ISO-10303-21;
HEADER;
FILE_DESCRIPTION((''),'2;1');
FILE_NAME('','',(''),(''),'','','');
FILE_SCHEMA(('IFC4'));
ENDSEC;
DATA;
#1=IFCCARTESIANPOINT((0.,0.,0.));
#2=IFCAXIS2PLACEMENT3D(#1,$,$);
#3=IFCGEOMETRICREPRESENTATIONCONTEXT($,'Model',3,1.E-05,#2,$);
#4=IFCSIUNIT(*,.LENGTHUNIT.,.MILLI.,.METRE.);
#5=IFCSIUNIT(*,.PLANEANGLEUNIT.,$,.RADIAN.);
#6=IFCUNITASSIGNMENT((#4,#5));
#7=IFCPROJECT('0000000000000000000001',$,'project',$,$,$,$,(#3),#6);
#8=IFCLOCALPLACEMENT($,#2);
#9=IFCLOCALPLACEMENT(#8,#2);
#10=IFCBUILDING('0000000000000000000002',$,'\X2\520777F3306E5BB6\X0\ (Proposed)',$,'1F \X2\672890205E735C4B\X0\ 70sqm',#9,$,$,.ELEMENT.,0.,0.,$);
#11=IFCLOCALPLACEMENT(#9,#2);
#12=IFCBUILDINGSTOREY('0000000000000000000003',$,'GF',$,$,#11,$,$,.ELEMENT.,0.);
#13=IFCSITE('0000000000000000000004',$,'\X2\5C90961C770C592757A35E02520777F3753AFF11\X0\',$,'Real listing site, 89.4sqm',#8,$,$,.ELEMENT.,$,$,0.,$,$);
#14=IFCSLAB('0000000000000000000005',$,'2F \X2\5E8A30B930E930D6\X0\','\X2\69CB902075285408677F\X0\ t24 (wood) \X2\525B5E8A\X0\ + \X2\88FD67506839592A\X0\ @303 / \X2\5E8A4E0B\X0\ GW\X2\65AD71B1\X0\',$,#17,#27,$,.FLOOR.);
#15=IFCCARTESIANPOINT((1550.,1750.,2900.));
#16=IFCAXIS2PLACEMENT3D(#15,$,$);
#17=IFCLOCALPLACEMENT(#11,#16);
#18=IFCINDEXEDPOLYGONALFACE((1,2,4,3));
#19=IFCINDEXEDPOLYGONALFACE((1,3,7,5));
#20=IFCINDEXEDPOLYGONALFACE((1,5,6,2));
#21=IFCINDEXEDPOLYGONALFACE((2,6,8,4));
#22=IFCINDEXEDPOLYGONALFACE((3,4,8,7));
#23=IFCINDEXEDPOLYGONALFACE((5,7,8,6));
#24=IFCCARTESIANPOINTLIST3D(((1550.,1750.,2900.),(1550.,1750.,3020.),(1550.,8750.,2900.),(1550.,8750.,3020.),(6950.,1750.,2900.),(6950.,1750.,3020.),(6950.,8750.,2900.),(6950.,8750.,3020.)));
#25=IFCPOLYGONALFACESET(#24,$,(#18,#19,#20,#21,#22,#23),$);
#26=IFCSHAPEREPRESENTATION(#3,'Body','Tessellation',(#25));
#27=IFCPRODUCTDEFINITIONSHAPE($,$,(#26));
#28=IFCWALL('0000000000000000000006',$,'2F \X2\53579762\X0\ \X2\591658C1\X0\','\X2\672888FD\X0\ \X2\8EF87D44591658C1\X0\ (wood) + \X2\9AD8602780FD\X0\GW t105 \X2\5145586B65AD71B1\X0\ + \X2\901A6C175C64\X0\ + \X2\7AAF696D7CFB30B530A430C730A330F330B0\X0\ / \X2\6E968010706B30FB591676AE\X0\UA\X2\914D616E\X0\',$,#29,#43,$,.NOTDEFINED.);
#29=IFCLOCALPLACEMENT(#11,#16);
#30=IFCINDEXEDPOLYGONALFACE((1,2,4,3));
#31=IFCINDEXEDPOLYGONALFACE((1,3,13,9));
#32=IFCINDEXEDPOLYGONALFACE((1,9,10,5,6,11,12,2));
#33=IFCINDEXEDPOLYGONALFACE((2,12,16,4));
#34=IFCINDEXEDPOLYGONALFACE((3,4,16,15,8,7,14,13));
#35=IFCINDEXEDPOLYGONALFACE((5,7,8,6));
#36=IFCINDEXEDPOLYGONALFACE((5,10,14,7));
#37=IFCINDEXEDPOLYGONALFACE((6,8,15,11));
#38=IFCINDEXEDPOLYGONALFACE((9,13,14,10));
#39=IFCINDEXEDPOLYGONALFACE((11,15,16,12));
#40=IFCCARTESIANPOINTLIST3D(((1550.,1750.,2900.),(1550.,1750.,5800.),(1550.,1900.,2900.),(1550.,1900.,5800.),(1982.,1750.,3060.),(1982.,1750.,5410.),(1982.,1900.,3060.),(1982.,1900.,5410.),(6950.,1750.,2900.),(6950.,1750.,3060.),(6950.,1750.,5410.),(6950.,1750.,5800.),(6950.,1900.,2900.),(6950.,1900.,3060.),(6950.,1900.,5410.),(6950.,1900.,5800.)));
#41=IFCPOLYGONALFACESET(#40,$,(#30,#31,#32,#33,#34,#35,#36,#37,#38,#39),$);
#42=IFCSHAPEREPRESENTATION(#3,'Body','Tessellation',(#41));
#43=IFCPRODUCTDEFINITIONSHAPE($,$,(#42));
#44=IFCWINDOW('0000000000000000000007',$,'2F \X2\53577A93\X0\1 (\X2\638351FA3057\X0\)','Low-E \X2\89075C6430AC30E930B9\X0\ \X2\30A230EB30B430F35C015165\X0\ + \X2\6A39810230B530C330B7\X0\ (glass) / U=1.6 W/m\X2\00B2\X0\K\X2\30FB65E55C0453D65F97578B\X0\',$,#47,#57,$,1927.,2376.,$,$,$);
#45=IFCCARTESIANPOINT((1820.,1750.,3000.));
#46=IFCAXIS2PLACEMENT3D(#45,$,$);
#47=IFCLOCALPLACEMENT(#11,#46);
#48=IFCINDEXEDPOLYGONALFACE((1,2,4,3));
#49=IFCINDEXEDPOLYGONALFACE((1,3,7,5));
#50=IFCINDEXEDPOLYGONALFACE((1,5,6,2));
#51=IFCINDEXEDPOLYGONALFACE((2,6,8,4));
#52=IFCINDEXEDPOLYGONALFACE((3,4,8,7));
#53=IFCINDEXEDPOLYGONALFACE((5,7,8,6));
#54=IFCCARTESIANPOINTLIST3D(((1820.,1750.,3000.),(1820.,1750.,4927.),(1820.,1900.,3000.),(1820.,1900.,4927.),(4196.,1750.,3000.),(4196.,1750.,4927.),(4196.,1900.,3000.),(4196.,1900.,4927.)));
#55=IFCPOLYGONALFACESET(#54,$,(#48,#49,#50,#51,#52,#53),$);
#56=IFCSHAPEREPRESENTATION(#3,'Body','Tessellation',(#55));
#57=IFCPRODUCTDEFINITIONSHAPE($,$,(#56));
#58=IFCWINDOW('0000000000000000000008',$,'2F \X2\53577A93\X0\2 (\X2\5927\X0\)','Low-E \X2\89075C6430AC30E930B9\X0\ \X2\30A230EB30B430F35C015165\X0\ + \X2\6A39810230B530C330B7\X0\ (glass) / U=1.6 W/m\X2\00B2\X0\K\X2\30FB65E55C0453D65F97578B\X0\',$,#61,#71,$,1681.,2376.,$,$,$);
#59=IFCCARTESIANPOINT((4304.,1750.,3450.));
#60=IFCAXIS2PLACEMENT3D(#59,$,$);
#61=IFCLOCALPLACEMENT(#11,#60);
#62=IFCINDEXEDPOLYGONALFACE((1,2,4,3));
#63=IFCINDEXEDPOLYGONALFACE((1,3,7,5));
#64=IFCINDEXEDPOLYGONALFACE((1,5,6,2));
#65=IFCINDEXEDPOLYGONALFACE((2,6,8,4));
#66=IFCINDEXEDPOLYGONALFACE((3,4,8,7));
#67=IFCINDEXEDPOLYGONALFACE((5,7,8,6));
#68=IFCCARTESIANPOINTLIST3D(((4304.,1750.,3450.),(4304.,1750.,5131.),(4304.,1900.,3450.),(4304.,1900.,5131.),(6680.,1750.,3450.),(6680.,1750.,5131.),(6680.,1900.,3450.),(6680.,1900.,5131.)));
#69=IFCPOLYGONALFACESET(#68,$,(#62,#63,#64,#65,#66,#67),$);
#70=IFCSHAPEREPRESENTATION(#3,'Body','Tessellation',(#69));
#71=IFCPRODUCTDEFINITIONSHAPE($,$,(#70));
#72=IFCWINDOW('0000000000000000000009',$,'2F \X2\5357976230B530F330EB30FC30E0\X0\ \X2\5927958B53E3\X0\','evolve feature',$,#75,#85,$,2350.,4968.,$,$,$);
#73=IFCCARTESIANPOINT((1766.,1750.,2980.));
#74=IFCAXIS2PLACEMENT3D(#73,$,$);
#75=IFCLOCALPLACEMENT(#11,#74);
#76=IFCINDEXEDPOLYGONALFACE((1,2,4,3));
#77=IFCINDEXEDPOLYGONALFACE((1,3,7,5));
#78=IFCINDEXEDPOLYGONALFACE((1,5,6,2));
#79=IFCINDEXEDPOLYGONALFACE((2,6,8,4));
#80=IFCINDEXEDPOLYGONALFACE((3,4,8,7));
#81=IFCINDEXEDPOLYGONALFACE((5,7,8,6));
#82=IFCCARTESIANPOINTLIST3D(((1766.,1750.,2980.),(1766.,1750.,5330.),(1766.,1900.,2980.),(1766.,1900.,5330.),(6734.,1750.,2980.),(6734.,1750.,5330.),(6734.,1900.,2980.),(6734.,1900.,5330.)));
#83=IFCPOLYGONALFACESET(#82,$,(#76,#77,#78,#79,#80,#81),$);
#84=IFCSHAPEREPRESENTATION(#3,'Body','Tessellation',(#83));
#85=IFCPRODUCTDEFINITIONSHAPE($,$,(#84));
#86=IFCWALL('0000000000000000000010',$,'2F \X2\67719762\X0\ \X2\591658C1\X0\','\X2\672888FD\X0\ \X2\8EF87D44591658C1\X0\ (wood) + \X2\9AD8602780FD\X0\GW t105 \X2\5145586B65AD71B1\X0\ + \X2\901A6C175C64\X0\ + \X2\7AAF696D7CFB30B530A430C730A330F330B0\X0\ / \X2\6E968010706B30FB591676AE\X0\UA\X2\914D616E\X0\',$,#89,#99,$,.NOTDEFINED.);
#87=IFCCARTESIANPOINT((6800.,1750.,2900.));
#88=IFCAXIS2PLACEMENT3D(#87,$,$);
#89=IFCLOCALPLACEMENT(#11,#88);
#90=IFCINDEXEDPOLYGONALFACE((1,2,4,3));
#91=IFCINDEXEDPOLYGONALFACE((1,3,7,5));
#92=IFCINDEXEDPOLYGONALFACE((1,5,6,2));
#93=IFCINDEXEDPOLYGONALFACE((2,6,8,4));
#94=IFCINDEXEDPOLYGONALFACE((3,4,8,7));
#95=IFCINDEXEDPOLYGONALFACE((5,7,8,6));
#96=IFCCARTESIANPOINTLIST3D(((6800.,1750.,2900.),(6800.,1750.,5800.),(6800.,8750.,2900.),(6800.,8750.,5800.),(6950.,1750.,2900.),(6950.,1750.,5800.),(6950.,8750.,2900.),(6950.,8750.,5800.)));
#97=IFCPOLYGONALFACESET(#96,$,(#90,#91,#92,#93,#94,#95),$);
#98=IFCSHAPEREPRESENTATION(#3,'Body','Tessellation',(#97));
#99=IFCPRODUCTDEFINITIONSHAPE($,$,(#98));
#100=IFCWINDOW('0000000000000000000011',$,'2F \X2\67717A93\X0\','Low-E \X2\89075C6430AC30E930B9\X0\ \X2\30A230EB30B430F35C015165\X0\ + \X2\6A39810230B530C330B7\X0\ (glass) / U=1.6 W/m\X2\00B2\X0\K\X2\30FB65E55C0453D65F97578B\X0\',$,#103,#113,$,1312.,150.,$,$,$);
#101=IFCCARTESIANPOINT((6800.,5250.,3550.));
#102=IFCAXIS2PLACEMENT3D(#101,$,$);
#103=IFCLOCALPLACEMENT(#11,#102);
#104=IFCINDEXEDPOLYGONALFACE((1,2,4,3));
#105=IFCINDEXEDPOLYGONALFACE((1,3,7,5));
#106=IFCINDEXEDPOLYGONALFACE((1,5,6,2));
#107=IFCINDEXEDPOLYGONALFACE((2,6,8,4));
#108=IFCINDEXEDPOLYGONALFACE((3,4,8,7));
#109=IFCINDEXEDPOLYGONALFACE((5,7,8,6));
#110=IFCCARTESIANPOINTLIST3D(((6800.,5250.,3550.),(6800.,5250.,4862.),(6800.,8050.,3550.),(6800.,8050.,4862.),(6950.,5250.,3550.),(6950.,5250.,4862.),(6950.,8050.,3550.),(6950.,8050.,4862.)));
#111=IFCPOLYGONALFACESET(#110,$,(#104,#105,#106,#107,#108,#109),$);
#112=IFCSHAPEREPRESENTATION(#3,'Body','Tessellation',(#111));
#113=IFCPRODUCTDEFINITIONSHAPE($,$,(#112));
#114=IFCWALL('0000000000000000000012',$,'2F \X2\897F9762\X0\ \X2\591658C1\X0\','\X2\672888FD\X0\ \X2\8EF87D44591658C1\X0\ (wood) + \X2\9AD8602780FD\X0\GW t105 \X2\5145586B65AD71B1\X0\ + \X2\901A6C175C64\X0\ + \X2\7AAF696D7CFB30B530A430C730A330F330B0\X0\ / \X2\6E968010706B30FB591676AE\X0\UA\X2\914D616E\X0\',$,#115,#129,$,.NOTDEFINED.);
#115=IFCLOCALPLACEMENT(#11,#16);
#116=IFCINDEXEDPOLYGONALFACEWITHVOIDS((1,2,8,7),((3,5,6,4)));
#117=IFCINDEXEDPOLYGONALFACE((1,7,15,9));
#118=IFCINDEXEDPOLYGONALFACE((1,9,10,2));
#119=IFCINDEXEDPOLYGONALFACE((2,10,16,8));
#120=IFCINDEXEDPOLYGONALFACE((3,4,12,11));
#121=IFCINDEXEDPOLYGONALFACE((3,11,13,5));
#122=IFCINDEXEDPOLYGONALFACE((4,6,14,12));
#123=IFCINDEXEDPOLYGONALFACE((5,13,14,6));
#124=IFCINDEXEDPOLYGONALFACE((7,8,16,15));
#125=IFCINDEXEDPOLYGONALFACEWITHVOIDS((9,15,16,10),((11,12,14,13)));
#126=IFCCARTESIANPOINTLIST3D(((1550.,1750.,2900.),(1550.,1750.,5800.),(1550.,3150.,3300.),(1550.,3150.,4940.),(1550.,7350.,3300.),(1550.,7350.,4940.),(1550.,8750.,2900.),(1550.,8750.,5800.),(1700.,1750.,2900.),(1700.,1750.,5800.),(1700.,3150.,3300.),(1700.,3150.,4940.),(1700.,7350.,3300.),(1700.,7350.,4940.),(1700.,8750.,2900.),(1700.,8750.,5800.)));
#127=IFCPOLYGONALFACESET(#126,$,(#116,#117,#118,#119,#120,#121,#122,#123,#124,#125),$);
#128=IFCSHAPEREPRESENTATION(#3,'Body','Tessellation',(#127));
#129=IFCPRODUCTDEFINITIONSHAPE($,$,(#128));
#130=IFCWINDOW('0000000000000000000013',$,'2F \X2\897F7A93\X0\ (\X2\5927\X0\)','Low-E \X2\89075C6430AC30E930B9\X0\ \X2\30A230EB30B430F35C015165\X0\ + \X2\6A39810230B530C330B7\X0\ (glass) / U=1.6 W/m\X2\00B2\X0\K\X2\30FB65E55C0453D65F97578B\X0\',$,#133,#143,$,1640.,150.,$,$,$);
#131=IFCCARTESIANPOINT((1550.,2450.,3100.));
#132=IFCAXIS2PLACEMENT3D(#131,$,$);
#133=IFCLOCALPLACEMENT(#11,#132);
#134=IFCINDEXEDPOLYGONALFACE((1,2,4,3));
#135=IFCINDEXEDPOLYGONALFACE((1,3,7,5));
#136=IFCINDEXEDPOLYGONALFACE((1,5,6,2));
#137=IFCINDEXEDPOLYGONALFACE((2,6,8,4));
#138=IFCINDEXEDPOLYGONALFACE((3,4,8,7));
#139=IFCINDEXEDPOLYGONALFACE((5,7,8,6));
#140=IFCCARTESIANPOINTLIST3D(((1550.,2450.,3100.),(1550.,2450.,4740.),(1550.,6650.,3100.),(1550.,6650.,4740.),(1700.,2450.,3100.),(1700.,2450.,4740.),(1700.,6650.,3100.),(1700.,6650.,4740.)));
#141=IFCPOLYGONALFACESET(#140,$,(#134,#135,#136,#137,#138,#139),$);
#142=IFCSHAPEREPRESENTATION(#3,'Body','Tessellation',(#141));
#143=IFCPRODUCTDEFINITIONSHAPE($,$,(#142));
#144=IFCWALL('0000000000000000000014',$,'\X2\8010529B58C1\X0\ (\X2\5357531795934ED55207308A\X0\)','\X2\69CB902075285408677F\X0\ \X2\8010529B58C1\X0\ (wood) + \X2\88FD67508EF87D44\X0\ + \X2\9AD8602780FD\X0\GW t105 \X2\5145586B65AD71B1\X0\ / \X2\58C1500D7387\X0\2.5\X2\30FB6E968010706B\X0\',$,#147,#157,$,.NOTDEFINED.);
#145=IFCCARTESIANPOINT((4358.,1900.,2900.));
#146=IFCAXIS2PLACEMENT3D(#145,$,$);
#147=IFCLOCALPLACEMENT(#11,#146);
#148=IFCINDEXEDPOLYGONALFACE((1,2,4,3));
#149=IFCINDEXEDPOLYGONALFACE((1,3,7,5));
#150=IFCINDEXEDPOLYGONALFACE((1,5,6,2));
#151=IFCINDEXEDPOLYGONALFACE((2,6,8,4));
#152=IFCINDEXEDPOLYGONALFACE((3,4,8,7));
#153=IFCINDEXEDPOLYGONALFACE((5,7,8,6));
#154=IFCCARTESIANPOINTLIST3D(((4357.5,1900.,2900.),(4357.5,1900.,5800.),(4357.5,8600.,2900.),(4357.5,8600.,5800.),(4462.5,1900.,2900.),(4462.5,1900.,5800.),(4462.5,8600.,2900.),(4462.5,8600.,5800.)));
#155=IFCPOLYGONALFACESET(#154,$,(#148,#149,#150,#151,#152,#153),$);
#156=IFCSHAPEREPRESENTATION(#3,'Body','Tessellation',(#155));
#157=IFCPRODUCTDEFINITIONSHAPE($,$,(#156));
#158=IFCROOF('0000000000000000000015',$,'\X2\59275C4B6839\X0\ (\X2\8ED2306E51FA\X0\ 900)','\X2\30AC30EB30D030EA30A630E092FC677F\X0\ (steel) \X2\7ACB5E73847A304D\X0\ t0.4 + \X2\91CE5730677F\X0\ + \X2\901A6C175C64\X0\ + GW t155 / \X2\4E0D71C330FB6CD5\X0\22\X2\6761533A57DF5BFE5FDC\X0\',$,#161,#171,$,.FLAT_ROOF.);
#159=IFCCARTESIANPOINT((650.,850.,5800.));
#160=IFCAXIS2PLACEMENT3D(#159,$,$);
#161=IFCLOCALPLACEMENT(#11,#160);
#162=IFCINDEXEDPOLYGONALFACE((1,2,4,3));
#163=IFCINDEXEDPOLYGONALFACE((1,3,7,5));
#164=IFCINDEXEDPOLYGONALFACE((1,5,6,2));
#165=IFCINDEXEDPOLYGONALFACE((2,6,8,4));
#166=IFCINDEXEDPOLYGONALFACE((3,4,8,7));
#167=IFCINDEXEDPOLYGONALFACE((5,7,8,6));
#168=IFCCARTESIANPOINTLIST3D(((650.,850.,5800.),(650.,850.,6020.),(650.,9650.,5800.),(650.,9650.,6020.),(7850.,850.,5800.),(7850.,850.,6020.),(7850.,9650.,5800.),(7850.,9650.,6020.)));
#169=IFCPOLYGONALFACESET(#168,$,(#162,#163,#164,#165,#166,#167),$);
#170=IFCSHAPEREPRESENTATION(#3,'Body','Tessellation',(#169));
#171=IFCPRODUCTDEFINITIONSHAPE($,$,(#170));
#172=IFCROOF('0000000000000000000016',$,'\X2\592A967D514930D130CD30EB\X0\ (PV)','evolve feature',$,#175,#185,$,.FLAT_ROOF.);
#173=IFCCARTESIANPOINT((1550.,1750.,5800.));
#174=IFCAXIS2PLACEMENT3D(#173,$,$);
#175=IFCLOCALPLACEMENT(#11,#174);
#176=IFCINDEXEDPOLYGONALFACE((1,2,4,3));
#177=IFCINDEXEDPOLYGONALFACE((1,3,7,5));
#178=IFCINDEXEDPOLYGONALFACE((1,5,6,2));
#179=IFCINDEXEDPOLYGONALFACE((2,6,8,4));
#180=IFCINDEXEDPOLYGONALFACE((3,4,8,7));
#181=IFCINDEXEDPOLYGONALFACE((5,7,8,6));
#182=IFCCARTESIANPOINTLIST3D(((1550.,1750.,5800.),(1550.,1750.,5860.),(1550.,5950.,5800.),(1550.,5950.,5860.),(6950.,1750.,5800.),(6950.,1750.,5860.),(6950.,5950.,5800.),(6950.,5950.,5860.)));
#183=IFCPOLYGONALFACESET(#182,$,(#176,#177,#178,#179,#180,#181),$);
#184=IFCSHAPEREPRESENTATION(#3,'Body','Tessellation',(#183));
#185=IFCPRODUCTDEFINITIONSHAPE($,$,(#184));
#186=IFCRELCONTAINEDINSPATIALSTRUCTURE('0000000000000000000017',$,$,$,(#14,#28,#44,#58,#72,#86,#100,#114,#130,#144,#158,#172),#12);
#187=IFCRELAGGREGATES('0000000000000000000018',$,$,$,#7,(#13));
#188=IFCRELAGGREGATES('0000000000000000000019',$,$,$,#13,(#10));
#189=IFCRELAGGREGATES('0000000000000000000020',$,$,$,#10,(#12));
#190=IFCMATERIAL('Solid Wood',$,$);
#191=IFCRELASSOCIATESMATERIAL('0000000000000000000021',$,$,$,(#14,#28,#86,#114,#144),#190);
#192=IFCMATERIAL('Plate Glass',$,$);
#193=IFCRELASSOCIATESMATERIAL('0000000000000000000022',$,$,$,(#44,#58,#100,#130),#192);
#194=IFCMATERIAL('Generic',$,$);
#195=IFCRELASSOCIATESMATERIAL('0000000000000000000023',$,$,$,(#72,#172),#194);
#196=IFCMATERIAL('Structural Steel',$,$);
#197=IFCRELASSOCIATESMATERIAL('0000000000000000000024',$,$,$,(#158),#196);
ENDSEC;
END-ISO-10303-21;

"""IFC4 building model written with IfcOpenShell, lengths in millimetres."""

from ifc_helpers import new_model, si_unit, frame, frame_2d, origin, place, context, project, spatial, rectangle, extrude, material, element, fill, save


model = new_model("IFC4")

# Units and contexts
model_context = context("Model", 3, precision=1e-05, world=origin())
ifc_project = project(units=[si_unit("LENGTHUNIT", "METRE", prefix="MILLI"), si_unit("PLANEANGLEUNIT", "RADIAN")], contexts=[model_context])

# Site, building, storey
site_placement = place(None, origin())
site = spatial("IfcSite", under=ifc_project, at=site_placement, Name="岐阜県大垣市切石町１", ObjectType="Real listing site, 89.4sqm", CompositionType="ELEMENT", RefElevation=0.0)
building_placement = place(site_placement, origin())
building = spatial("IfcBuilding", under=site, at=building_placement, Name="切石の家 (Proposed)", ObjectType="1F 木造平屋 70sqm", CompositionType="ELEMENT", ElevationOfRefHeight=0.0, ElevationOfTerrain=0.0)
storey_placement = place(building_placement, origin())
storey = spatial("IfcBuildingStorey", under=building, at=storey_placement, Name="GF", CompositionType="ELEMENT", Elevation=0.0)

# Slab
ifc_material_1 = material(Name="Solid Wood")
slab_placement = place(storey_placement, frame((1550.0, 1750.0, 2900.0)))
element("IfcSlab", 1, at=slab_placement, inside=storey, material=ifc_material_1, Name="2F 床スラブ", Description="構造用合板 t24 (wood) 剛床 + 製材根太 @303 / 床下 GW断熱", PredefinedType="FLOOR", context=model_context, shape_type="SweptSolid", body=[
    extrude(rectangle(XDim=5400.0, YDim=7000.0, at=frame_2d((2700.0, 3500.0))), frame((1550.0, 1750.0, 2900.0)), (0.0, 0.0, 1.0), 120.0),
])

# Wall, openings, windows
wall_1_placement = place(storey_placement, frame((1550.0, 1750.0, 2900.0)))
wall_1 = element("IfcWall", 2, at=wall_1_placement, inside=storey, material=ifc_material_1, Name="2F 南面 外壁", Description="木製 軸組外壁 (wood) + 高性能GW t105 充填断熱 + 通気層 + 窯業系サイディング / 準耐火・外皮UA配慮", PredefinedType="NOTDEFINED", context=model_context, shape_type="SweptSolid", body=[
    extrude(rectangle(XDim=5400.0, YDim=150.0, at=frame_2d((2700.0, 75.0))), frame((1550.0, 1750.0, 2900.0)), (0.0, 0.0, 1.0), 2900.0),
])
opening_1_placement = place(storey_placement, frame((1820.0, 1750.0, 3000.0)))
opening_1 = element("IfcOpeningElement", 3, at=opening_1_placement, cuts=wall_1, PredefinedType="NOTDEFINED", context=model_context, shape_type="SweptSolid", body=[
    extrude(rectangle(XDim=2376.0, YDim=150.0, at=frame_2d((1188.0, 75.0))), frame((1820.0, 1750.0, 3000.0)), (0.0, 0.0, 1.0), 1927.0),
])
opening_2_placement = place(storey_placement, frame((4304.0, 1750.0, 3450.0)))
opening_2 = element("IfcOpeningElement", 4, at=opening_2_placement, cuts=wall_1, PredefinedType="NOTDEFINED", context=model_context, shape_type="SweptSolid", body=[
    extrude(rectangle(XDim=2376.0, YDim=150.0, at=frame_2d((1188.0, 75.0))), frame((4304.0, 1750.0, 3450.0)), (0.0, 0.0, 1.0), 1681.0),
])
opening_3_placement = place(storey_placement, frame((1766.0, 1750.0, 2980.0)))
opening_3 = element("IfcOpeningElement", 5, at=opening_3_placement, cuts=wall_1, PredefinedType="NOTDEFINED", context=model_context, shape_type="SweptSolid", body=[
    extrude(rectangle(XDim=4968.0, YDim=150.0, at=frame_2d((2484.0, 75.0))), frame((1766.0, 1750.0, 2980.0)), (0.0, 0.0, 1.0), 2350.0),
])
ifc_material_2 = material(Name="Plate Glass")
window_1_placement = place(storey_placement, frame((1820.0, 1750.0, 3000.0)))
window_1 = element("IfcWindow", 6, at=window_1_placement, inside=storey, material=ifc_material_2, Name="2F 南窓1 (掃出し)", Description="Low-E 複層ガラス アルゴン封入 + 樹脂サッシ (glass) / U=1.6 W/m²K・日射取得型", OverallHeight=1927.0, OverallWidth=2376.0, context=model_context, shape_type="SweptSolid", body=[
    extrude(rectangle(XDim=2376.0, YDim=150.0, at=frame_2d((1188.0, 75.0))), frame((1820.0, 1750.0, 3000.0)), (0.0, 0.0, 1.0), 1927.0),
])
fill(opening_1, window_1)
window_2_placement = place(storey_placement, frame((4304.0, 1750.0, 3450.0)))
window_2 = element("IfcWindow", 7, at=window_2_placement, inside=storey, material=ifc_material_2, Name="2F 南窓2 (大)", Description="Low-E 複層ガラス アルゴン封入 + 樹脂サッシ (glass) / U=1.6 W/m²K・日射取得型", OverallHeight=1681.0, OverallWidth=2376.0, context=model_context, shape_type="SweptSolid", body=[
    extrude(rectangle(XDim=2376.0, YDim=150.0, at=frame_2d((1188.0, 75.0))), frame((4304.0, 1750.0, 3450.0)), (0.0, 0.0, 1.0), 1681.0),
])
fill(opening_2, window_2)
ifc_material_3 = material(Name="Generic")
window_3_placement = place(storey_placement, frame((1766.0, 1750.0, 2980.0)))
window_3 = element("IfcWindow", 8, at=window_3_placement, inside=storey, material=ifc_material_3, Name="2F 南面サンルーム 大開口", Description="evolve feature", OverallHeight=2350.0, OverallWidth=4968.0, context=model_context, shape_type="SweptSolid", body=[
    extrude(rectangle(XDim=4968.0, YDim=150.0, at=frame_2d((2484.0, 75.0))), frame((1766.0, 1750.0, 2980.0)), (0.0, 0.0, 1.0), 2350.0),
])
fill(opening_3, window_3)

# Walls, openings, windows
wall_2_placement = place(storey_placement, frame((6800.0, 1750.0, 2900.0)))
wall_2 = element("IfcWall", 9, at=wall_2_placement, inside=storey, material=ifc_material_1, Name="2F 東面 外壁", Description="木製 軸組外壁 (wood) + 高性能GW t105 充填断熱 + 通気層 + 窯業系サイディング / 準耐火・外皮UA配慮", PredefinedType="NOTDEFINED", context=model_context, shape_type="SweptSolid", body=[
    extrude(rectangle(XDim=150.0, YDim=7000.0, at=frame_2d((75.0, 3500.0))), frame((6800.0, 1750.0, 2900.0)), (0.0, 0.0, 1.0), 2900.0),
])
opening_4_placement = place(storey_placement, frame((6800.0, 5250.0, 3550.0)))
opening_4 = element("IfcOpeningElement", 10, at=opening_4_placement, cuts=wall_2, PredefinedType="NOTDEFINED", context=model_context, shape_type="SweptSolid", body=[
    extrude(rectangle(XDim=150.0, YDim=2800.0, at=frame_2d((75.0, 1400.0))), frame((6800.0, 5250.0, 3550.0)), (0.0, 0.0, 1.0), 1312.0),
])
window_4_placement = place(storey_placement, frame((6800.0, 5250.0, 3550.0)))
window_4 = element("IfcWindow", 11, at=window_4_placement, inside=storey, material=ifc_material_2, Name="2F 東窓", Description="Low-E 複層ガラス アルゴン封入 + 樹脂サッシ (glass) / U=1.6 W/m²K・日射取得型", OverallHeight=1312.0, OverallWidth=150.0, context=model_context, shape_type="SweptSolid", body=[
    extrude(rectangle(XDim=150.0, YDim=2800.0, at=frame_2d((75.0, 1400.0))), frame((6800.0, 5250.0, 3550.0)), (0.0, 0.0, 1.0), 1312.0),
])
fill(opening_4, window_4)
wall_3_placement = place(storey_placement, frame((1550.0, 1750.0, 2900.0)))
wall_3 = element("IfcWall", 12, at=wall_3_placement, inside=storey, material=ifc_material_1, Name="2F 西面 外壁", Description="木製 軸組外壁 (wood) + 高性能GW t105 充填断熱 + 通気層 + 窯業系サイディング / 準耐火・外皮UA配慮", PredefinedType="NOTDEFINED", context=model_context, shape_type="SweptSolid", body=[
    extrude(rectangle(XDim=150.0, YDim=7000.0, at=frame_2d((75.0, 3500.0))), frame((1550.0, 1750.0, 2900.0)), (0.0, 0.0, 1.0), 2900.0),
])
opening_5_placement = place(storey_placement, frame((1550.0, 2450.0, 3100.0)))
opening_5 = element("IfcOpeningElement", 13, at=opening_5_placement, cuts=wall_3, PredefinedType="NOTDEFINED", context=model_context, shape_type="SweptSolid", body=[
    extrude(rectangle(XDim=150.0, YDim=4200.0, at=frame_2d((75.0, 2100.0))), frame((1550.0, 2450.0, 3100.0)), (0.0, 0.0, 1.0), 1640.0),
])
window_5_placement = place(storey_placement, frame((1550.0, 2450.0, 3100.0)))
window_5 = element("IfcWindow", 14, at=window_5_placement, inside=storey, material=ifc_material_2, Name="2F 西窓 (大)", Description="Low-E 複層ガラス アルゴン封入 + 樹脂サッシ (glass) / U=1.6 W/m²K・日射取得型", OverallHeight=1640.0, OverallWidth=150.0, context=model_context, shape_type="SweptSolid", body=[
    extrude(rectangle(XDim=150.0, YDim=4200.0, at=frame_2d((75.0, 2100.0))), frame((1550.0, 2450.0, 3100.0)), (0.0, 0.0, 1.0), 1640.0),
])
fill(opening_5, window_5)

# Wall
wall_4_placement = place(storey_placement, frame((4358.0, 1900.0, 2900.0)))
element("IfcWall", 15, at=wall_4_placement, inside=storey, material=ifc_material_1, Name="耐力壁 (南北間仕切り)", Description="構造用合板 耐力壁 (wood) + 製材軸組 + 高性能GW t105 充填断熱 / 壁倍率2.5・準耐火", PredefinedType="NOTDEFINED", context=model_context, shape_type="SweptSolid", body=[
    extrude(rectangle(XDim=105.0, YDim=6700.0, at=frame_2d((52.0, 3350.0))), frame((4358.0, 1900.0, 2900.0)), (0.0, 0.0, 1.0), 2900.0),
])

# Roofs
ifc_material_4 = material(Name="Structural Steel")
roof_1_placement = place(storey_placement, frame((650.0, 850.0, 5800.0)))
element("IfcRoof", 16, at=roof_1_placement, inside=storey, material=ifc_material_4, Name="大屋根 (軒の出 900)", Description="ガルバリウム鋼板 (steel) 立平葺き t0.4 + 野地板 + 通気層 + GW t155 / 不燃・法22条区域対応", PredefinedType="FLAT_ROOF", context=model_context, shape_type="SweptSolid", body=[
    extrude(rectangle(XDim=7200.0, YDim=8800.0, at=frame_2d((3600.0, 4400.0))), frame((650.0, 850.0, 5800.0)), (0.0, 0.0, 1.0), 220.0),
])
roof_2_placement = place(storey_placement, frame((1550.0, 1750.0, 5800.0)))
element("IfcRoof", 17, at=roof_2_placement, inside=storey, material=ifc_material_3, Name="太陽光パネル (PV)", Description="evolve feature", PredefinedType="FLAT_ROOF", context=model_context, shape_type="SweptSolid", body=[
    extrude(rectangle(XDim=5400.0, YDim=4200.0, at=frame_2d((2700.0, 2100.0))), frame((1550.0, 1750.0, 5800.0)), (0.0, 0.0, 1.0), 60.0),
])

save(model, "model.ifc")
